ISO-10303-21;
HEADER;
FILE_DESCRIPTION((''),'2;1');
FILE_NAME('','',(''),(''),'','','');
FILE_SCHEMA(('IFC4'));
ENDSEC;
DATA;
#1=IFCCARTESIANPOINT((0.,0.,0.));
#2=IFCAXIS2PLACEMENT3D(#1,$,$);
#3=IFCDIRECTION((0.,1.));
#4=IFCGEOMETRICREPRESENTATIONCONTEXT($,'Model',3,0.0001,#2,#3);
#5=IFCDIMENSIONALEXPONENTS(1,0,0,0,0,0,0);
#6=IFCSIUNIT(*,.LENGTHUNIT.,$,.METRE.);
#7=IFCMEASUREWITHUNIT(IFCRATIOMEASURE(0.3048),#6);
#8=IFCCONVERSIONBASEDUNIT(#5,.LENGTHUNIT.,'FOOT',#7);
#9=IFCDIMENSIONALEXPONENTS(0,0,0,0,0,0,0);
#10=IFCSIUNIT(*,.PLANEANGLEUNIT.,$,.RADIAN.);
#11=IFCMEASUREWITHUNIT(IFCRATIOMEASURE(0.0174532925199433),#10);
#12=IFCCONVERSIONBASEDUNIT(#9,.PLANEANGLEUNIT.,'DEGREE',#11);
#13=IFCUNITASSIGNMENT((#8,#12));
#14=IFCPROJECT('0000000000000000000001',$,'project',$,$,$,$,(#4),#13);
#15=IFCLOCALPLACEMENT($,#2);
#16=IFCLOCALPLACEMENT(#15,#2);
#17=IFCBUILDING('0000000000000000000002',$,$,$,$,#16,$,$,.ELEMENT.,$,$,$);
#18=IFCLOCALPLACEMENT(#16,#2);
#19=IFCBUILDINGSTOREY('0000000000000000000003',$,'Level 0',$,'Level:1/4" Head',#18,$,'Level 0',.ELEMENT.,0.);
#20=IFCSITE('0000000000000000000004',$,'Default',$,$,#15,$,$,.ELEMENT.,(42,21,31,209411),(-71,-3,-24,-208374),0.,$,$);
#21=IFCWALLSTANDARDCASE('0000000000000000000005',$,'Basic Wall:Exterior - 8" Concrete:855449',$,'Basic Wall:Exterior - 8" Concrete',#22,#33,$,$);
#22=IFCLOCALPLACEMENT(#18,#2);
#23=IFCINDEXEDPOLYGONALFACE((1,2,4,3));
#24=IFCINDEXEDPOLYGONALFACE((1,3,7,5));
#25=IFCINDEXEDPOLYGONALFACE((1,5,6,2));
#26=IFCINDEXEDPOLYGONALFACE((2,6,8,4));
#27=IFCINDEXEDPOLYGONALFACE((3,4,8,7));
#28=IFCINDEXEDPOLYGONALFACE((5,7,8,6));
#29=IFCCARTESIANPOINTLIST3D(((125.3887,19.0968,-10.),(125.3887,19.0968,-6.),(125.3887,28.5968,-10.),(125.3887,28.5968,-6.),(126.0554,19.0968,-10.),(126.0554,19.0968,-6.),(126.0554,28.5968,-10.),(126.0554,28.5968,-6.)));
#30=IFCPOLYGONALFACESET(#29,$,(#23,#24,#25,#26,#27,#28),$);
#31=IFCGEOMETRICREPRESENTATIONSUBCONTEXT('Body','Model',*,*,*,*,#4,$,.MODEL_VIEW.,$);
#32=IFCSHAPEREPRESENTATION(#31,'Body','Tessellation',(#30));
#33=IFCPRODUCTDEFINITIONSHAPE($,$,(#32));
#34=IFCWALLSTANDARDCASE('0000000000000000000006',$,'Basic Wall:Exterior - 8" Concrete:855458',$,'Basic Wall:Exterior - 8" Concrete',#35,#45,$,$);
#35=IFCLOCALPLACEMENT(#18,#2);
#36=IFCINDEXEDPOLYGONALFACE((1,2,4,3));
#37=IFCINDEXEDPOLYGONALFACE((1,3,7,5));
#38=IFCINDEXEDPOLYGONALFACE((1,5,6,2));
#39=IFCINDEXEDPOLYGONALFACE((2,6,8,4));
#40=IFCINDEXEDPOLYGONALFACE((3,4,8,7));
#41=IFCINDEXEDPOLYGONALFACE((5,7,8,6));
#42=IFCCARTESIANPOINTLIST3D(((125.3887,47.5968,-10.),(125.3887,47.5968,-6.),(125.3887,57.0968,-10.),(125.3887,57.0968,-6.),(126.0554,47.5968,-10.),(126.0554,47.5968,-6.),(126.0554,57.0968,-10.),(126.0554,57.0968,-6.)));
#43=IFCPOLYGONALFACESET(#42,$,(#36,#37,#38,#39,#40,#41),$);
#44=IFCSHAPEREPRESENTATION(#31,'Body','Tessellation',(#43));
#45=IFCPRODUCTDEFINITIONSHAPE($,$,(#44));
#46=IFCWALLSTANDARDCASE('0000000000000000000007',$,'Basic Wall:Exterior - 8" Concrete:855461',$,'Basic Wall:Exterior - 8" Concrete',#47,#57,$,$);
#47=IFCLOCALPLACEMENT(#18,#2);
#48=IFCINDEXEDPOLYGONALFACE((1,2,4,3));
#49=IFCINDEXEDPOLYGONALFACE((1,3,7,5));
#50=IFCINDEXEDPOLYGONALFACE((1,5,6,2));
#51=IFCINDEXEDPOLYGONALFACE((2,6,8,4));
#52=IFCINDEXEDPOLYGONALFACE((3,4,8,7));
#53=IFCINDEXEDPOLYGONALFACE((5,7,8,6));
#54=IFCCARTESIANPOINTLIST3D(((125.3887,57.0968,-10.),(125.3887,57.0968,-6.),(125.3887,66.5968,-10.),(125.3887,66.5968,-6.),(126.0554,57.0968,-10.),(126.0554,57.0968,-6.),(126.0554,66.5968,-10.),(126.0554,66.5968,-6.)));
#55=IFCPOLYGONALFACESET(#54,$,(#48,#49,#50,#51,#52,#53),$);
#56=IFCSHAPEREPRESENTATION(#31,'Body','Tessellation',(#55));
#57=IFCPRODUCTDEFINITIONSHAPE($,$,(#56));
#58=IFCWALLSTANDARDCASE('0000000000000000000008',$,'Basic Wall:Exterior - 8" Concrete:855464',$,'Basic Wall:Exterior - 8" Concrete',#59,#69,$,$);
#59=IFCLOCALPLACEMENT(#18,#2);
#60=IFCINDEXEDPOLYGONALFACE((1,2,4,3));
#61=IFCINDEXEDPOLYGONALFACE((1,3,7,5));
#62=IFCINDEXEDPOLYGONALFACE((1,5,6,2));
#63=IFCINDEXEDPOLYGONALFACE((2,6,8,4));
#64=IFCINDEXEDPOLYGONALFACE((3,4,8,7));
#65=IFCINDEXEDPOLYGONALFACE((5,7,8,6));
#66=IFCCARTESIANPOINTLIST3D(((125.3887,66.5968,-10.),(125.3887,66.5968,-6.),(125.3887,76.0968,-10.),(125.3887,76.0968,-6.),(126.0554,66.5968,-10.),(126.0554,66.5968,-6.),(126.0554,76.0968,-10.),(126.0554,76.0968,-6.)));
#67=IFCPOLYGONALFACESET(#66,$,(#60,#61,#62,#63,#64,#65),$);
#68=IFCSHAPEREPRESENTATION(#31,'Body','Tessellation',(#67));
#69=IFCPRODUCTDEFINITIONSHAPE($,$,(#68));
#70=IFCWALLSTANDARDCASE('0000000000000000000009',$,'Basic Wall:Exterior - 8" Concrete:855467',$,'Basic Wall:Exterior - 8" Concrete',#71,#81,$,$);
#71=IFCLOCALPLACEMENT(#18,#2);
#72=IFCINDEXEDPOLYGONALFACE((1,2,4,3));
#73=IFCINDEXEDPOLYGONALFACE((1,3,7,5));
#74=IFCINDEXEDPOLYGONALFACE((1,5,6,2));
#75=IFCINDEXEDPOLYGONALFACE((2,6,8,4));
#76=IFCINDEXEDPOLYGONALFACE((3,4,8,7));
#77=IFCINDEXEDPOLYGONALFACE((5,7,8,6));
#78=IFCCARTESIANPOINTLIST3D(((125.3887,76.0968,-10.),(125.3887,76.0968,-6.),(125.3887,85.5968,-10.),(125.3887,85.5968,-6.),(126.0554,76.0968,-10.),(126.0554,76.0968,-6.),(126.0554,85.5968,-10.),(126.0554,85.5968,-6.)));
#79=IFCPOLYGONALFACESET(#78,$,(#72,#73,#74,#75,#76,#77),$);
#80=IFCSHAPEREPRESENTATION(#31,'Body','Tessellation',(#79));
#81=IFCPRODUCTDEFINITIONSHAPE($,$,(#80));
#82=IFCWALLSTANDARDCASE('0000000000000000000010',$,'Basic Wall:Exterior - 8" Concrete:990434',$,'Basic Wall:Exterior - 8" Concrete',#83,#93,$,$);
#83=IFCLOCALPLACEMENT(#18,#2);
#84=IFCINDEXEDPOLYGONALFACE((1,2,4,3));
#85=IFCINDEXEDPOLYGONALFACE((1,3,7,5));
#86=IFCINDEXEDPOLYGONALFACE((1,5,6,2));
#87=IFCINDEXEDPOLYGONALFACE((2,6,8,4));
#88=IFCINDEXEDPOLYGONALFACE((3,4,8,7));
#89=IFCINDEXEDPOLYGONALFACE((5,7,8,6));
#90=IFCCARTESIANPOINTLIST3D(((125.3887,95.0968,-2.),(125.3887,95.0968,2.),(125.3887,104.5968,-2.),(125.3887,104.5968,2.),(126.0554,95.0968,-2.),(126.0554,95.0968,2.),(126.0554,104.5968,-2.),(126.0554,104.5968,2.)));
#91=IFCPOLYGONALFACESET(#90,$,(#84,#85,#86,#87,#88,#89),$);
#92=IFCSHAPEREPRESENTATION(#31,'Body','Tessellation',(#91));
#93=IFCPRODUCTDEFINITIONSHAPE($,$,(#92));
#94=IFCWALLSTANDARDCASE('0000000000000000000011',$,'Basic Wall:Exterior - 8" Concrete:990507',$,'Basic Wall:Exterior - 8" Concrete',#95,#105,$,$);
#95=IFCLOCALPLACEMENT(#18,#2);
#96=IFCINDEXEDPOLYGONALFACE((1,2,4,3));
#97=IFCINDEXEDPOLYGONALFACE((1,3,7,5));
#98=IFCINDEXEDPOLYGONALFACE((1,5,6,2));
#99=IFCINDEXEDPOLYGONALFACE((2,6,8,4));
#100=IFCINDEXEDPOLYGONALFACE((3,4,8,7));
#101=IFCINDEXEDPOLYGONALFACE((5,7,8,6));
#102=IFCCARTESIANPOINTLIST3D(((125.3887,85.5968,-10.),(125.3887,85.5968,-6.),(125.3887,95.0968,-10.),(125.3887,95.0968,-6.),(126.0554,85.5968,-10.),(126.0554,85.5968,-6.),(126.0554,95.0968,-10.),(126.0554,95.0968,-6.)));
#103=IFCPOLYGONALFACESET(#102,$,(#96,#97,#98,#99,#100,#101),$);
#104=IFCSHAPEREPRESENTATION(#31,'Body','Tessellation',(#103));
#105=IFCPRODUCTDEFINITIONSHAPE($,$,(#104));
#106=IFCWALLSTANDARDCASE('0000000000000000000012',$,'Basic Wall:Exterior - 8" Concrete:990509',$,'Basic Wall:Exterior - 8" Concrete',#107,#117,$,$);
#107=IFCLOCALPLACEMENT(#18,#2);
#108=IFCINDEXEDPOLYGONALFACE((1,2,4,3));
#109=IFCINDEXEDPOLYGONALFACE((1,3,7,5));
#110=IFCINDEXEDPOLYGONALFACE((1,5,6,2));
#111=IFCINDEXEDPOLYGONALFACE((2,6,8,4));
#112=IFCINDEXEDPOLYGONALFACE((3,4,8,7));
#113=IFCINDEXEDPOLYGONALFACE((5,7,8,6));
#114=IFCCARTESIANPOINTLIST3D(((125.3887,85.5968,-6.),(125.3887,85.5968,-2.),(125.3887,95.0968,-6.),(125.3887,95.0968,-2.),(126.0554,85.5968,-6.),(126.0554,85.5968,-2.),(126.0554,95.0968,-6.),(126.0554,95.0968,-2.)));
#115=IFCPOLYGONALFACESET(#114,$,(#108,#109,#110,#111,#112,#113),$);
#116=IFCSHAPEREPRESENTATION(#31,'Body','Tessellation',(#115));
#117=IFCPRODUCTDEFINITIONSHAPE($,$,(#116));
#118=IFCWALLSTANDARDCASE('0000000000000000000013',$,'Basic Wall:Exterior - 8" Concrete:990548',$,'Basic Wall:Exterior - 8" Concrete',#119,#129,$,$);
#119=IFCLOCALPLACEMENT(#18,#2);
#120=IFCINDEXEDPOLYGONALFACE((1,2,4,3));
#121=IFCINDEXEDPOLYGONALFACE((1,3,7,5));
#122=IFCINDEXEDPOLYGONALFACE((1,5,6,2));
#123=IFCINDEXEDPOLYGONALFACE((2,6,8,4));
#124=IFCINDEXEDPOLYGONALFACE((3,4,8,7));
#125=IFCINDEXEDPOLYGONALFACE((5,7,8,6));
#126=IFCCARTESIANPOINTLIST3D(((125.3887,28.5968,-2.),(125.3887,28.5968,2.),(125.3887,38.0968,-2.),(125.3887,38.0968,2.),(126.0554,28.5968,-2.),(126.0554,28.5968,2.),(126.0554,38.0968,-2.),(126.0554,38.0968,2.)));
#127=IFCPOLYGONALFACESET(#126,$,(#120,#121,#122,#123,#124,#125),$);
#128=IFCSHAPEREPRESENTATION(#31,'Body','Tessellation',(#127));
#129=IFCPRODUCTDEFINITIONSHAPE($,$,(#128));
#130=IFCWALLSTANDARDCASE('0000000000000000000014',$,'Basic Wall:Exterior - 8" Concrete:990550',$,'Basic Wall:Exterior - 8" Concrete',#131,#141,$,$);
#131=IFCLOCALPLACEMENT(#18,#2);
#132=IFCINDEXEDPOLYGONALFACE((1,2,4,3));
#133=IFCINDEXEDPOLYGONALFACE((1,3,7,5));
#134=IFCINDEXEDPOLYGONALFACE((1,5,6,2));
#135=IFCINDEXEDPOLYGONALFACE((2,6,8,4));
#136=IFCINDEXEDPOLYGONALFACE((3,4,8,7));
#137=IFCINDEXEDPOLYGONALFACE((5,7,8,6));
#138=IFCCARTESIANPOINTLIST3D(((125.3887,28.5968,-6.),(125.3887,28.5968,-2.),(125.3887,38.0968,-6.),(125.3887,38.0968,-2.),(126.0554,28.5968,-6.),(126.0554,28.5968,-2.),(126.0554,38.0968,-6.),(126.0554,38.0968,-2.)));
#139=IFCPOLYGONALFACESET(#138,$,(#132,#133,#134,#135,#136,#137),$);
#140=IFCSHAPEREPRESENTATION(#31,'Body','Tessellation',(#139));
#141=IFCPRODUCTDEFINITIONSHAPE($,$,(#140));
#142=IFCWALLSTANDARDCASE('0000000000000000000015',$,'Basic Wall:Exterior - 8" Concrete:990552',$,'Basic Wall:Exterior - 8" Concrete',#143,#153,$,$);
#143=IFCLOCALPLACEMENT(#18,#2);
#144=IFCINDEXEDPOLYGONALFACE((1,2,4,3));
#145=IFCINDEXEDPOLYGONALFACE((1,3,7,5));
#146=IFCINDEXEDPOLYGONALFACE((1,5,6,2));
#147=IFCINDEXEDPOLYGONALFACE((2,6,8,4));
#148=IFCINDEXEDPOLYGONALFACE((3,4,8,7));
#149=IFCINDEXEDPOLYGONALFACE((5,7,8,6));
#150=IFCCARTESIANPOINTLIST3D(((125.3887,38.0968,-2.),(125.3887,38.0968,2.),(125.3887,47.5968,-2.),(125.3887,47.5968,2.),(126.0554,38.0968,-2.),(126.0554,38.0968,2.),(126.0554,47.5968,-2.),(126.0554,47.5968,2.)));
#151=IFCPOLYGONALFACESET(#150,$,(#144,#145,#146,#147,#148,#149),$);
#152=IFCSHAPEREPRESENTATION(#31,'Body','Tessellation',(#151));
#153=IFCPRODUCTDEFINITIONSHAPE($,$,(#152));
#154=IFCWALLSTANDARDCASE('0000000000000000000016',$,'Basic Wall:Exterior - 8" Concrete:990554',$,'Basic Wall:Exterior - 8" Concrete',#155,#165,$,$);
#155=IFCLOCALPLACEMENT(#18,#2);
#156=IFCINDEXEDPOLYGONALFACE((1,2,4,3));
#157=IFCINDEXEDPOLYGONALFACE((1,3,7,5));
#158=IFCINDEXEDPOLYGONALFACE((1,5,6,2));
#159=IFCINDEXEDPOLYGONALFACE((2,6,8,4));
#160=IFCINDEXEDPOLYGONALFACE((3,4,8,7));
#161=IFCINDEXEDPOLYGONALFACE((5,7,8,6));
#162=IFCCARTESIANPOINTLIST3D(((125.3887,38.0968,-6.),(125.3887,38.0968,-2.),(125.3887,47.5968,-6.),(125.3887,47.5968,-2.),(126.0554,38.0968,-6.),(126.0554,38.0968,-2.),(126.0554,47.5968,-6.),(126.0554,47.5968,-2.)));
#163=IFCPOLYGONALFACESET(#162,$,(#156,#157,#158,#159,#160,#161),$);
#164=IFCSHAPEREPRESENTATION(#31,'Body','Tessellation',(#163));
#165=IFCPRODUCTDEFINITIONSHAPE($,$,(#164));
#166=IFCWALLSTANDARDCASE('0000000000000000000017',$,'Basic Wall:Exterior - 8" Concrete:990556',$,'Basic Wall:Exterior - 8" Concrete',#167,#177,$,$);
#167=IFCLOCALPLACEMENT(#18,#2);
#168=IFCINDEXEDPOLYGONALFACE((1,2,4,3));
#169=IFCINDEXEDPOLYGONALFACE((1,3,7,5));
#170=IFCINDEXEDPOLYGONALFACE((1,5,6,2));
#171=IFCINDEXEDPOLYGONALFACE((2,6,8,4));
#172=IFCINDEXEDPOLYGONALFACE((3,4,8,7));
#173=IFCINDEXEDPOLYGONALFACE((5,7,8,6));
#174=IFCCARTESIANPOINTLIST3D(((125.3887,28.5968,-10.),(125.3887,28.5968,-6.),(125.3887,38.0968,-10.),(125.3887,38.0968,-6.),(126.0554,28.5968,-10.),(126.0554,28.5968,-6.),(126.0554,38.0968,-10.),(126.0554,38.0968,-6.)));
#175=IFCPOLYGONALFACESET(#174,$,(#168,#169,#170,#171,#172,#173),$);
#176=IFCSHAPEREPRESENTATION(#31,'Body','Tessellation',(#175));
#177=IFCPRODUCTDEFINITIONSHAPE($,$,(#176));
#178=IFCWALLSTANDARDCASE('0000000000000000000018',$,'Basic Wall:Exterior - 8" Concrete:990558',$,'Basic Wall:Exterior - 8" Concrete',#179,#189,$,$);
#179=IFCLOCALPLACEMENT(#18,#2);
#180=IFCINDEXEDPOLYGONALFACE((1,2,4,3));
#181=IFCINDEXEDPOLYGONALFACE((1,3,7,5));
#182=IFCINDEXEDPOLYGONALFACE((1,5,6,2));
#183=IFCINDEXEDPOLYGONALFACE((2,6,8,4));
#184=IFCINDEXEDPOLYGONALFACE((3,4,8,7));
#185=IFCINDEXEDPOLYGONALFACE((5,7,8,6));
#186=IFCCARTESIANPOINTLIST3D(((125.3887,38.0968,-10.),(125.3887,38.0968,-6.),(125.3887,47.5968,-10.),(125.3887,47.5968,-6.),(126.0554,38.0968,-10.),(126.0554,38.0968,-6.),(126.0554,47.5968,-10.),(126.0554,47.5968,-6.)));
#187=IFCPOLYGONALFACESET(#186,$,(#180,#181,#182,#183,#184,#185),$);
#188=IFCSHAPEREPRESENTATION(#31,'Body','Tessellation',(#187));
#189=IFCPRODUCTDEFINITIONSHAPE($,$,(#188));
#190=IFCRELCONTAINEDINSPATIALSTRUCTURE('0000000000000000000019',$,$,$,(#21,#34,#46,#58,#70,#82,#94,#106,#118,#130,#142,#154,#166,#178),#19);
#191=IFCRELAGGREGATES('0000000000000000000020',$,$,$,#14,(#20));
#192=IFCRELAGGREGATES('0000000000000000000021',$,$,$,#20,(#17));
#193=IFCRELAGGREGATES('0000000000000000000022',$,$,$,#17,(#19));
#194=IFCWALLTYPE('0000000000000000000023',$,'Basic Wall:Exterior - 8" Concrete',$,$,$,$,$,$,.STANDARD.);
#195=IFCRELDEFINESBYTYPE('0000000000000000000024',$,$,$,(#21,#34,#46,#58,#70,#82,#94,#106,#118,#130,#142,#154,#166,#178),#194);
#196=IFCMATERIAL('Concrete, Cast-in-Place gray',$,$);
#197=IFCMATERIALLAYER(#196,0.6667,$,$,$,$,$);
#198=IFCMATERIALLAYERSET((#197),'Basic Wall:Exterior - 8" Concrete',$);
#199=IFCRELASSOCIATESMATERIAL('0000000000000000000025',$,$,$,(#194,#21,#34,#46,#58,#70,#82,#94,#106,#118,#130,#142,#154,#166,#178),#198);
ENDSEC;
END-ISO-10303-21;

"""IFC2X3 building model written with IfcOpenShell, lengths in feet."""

from ifc_helpers import new_model, entity, si_unit, converted_unit, direction, frame, frame_2d, origin, place, context, subcontext, project, spatial, rectangle, extrude, material, layer, layer_set, layer_usage, type_object, element, save


model = new_model("IFC2X3")

# Units and contexts
model_context = context("Model", 3, precision=0.0001, world=origin(), true_north=direction((0.0, 1.0)))
body_context = subcontext(model_context, "Body", "Model", "MODEL_VIEW")
ifc_project = project(units=[converted_unit("LENGTHUNIT", "FOOT", entity("IfcRatioMeasure", 0.3048), si_unit("LENGTHUNIT", "METRE"), dimensions=[1, 0, 0, 0, 0, 0, 0]), converted_unit("PLANEANGLEUNIT", "DEGREE", entity("IfcRatioMeasure", 0.0174532925199433), si_unit("PLANEANGLEUNIT", "RADIAN"), dimensions=[0, 0, 0, 0, 0, 0, 0])], contexts=[model_context])

# Site, building, storey
site_placement = place(None, origin())
site = spatial("IfcSite", under=ifc_project, at=site_placement, Name="Default", CompositionType="ELEMENT", RefLatitude=(42, 21, 31, 209411), RefLongitude=(-71, -3, -24, -208374), RefElevation=0.0)
building_placement = place(site_placement, origin())
building = spatial("IfcBuilding", under=site, at=building_placement, CompositionType="ELEMENT")
storey_placement = place(building_placement, origin())
storey = spatial("IfcBuildingStorey", under=building, at=storey_placement, Name="Level 0", ObjectType="Level:1/4\" Head", LongName="Level 0", CompositionType="ELEMENT", Elevation=0.0)

# Walls
ifc_material_1 = material(Name="Concrete, Cast-in-Place gray")
ifc_layer = layer(ifc_material_1, 0.6667)
ifc_layer_set = layer_set([ifc_layer], Name="Basic Wall:Exterior - 8\" Concrete")
wall_type = type_object("IfcWallType", Name="Basic Wall:Exterior - 8\" Concrete", PredefinedType="STANDARD", material=ifc_layer_set)
ifc_layer_usage_1 = layer_usage(ifc_layer_set, "AXIS2", "NEGATIVE", 0.3333)
wall_1_placement = place(storey_placement, frame((125.722, 19.0968, -10.0), z_axis=(0.0, 0.0, 1.0), x_axis=(0.0, 1.0, 0.0)))
element("IfcWallStandardCase", 1, at=wall_1_placement, inside=storey, type_object=wall_type, material=ifc_layer_usage_1, Name="Basic Wall:Exterior - 8\" Concrete:855449", ObjectType="Basic Wall:Exterior - 8\" Concrete", context=body_context, shape_type="SweptSolid", body=[
    extrude(rectangle(XDim=9.5, YDim=0.6667, at=frame_2d((4.75, 0.0), x_axis=(-1.0, 0.0))), origin(), (0.0, 0.0, 1.0), 4.0),
])
ifc_layer_usage_2 = layer_usage(ifc_layer_set, "AXIS2", "NEGATIVE", 0.3333)
wall_2_placement = place(storey_placement, frame((125.722, 47.5968, -10.0), z_axis=(0.0, 0.0, 1.0), x_axis=(0.0, 1.0, 0.0)))
element("IfcWallStandardCase", 2, at=wall_2_placement, inside=storey, type_object=wall_type, material=ifc_layer_usage_2, Name="Basic Wall:Exterior - 8\" Concrete:855458", ObjectType="Basic Wall:Exterior - 8\" Concrete", context=body_context, shape_type="SweptSolid", body=[
    extrude(rectangle(XDim=9.5, YDim=0.6667, at=frame_2d((4.75, 0.0), x_axis=(-1.0, 0.0))), origin(), (0.0, 0.0, 1.0), 4.0),
])
ifc_layer_usage_3 = layer_usage(ifc_layer_set, "AXIS2", "NEGATIVE", 0.3333)
wall_3_placement = place(storey_placement, frame((125.722, 57.0968, -10.0), z_axis=(0.0, 0.0, 1.0), x_axis=(0.0, 1.0, 0.0)))
element("IfcWallStandardCase", 3, at=wall_3_placement, inside=storey, type_object=wall_type, material=ifc_layer_usage_3, Name="Basic Wall:Exterior - 8\" Concrete:855461", ObjectType="Basic Wall:Exterior - 8\" Concrete", context=body_context, shape_type="SweptSolid", body=[
    extrude(rectangle(XDim=9.5, YDim=0.6667, at=frame_2d((4.75, 0.0), x_axis=(-1.0, 0.0))), origin(), (0.0, 0.0, 1.0), 4.0),
])
ifc_layer_usage_4 = layer_usage(ifc_layer_set, "AXIS2", "NEGATIVE", 0.3333)
wall_4_placement = place(storey_placement, frame((125.722, 66.5968, -10.0), z_axis=(0.0, 0.0, 1.0), x_axis=(0.0, 1.0, 0.0)))
element("IfcWallStandardCase", 4, at=wall_4_placement, inside=storey, type_object=wall_type, material=ifc_layer_usage_4, Name="Basic Wall:Exterior - 8\" Concrete:855464", ObjectType="Basic Wall:Exterior - 8\" Concrete", context=body_context, shape_type="SweptSolid", body=[
    extrude(rectangle(XDim=9.5, YDim=0.6667, at=frame_2d((4.75, 0.0), x_axis=(-1.0, 0.0))), origin(), (0.0, 0.0, 1.0), 4.0),
])
ifc_layer_usage_5 = layer_usage(ifc_layer_set, "AXIS2", "NEGATIVE", 0.3333)
wall_5_placement = place(storey_placement, frame((125.722, 76.0968, -10.0), z_axis=(0.0, 0.0, 1.0), x_axis=(0.0, 1.0, 0.0)))
element("IfcWallStandardCase", 5, at=wall_5_placement, inside=storey, type_object=wall_type, material=ifc_layer_usage_5, Name="Basic Wall:Exterior - 8\" Concrete:855467", ObjectType="Basic Wall:Exterior - 8\" Concrete", context=body_context, shape_type="SweptSolid", body=[
    extrude(rectangle(XDim=9.5, YDim=0.6667, at=frame_2d((4.75, 0.0), x_axis=(-1.0, 0.0))), origin(), (0.0, 0.0, 1.0), 4.0),
])
ifc_layer_usage_6 = layer_usage(ifc_layer_set, "AXIS2", "NEGATIVE", 0.3333)
wall_6_placement = place(storey_placement, frame((125.722, 95.0968, -2.0), z_axis=(0.0, 0.0, 1.0), x_axis=(0.0, 1.0, 0.0)))
element("IfcWallStandardCase", 6, at=wall_6_placement, inside=storey, type_object=wall_type, material=ifc_layer_usage_6, Name="Basic Wall:Exterior - 8\" Concrete:990434", ObjectType="Basic Wall:Exterior - 8\" Concrete", context=body_context, shape_type="SweptSolid", body=[
    extrude(rectangle(XDim=9.5, YDim=0.6667, at=frame_2d((4.75, 0.0), x_axis=(-1.0, 0.0))), origin(), (0.0, 0.0, 1.0), 4.0),
])
ifc_layer_usage_7 = layer_usage(ifc_layer_set, "AXIS2", "NEGATIVE", 0.3333)
wall_7_placement = place(storey_placement, frame((125.722, 85.5968, -10.0), z_axis=(0.0, 0.0, 1.0), x_axis=(0.0, 1.0, 0.0)))
element("IfcWallStandardCase", 7, at=wall_7_placement, inside=storey, type_object=wall_type, material=ifc_layer_usage_7, Name="Basic Wall:Exterior - 8\" Concrete:990507", ObjectType="Basic Wall:Exterior - 8\" Concrete", context=body_context, shape_type="SweptSolid", body=[
    extrude(rectangle(XDim=9.5, YDim=0.6667, at=frame_2d((4.75, 0.0), x_axis=(-1.0, 0.0))), origin(), (0.0, 0.0, 1.0), 4.0),
])
ifc_layer_usage_8 = layer_usage(ifc_layer_set, "AXIS2", "NEGATIVE", 0.3333)
wall_8_placement = place(storey_placement, frame((125.722, 85.5968, -6.0), z_axis=(0.0, 0.0, 1.0), x_axis=(0.0, 1.0, 0.0)))
element("IfcWallStandardCase", 8, at=wall_8_placement, inside=storey, type_object=wall_type, material=ifc_layer_usage_8, Name="Basic Wall:Exterior - 8\" Concrete:990509", ObjectType="Basic Wall:Exterior - 8\" Concrete", context=body_context, shape_type="SweptSolid", body=[
    extrude(rectangle(XDim=9.5, YDim=0.6667, at=frame_2d((4.75, 0.0), x_axis=(-1.0, 0.0))), origin(), (0.0, 0.0, 1.0), 4.0),
])
ifc_layer_usage_9 = layer_usage(ifc_layer_set, "AXIS2", "NEGATIVE", 0.3333)
wall_9_placement = place(storey_placement, frame((125.722, 28.5968, -2.0), z_axis=(0.0, 0.0, 1.0), x_axis=(0.0, 1.0, 0.0)))
element("IfcWallStandardCase", 9, at=wall_9_placement, inside=storey, type_object=wall_type, material=ifc_layer_usage_9, Name="Basic Wall:Exterior - 8\" Concrete:990548", ObjectType="Basic Wall:Exterior - 8\" Concrete", context=body_context, shape_type="SweptSolid", body=[
    extrude(rectangle(XDim=9.5, YDim=0.6667, at=frame_2d((4.75, 0.0), x_axis=(-1.0, 0.0))), origin(), (0.0, 0.0, 1.0), 4.0),
])
ifc_layer_usage_10 = layer_usage(ifc_layer_set, "AXIS2", "NEGATIVE", 0.3333)
wall_10_placement = place(storey_placement, frame((125.722, 28.5968, -6.0), z_axis=(0.0, 0.0, 1.0), x_axis=(0.0, 1.0, 0.0)))
element("IfcWallStandardCase", 10, at=wall_10_placement, inside=storey, type_object=wall_type, material=ifc_layer_usage_10, Name="Basic Wall:Exterior - 8\" Concrete:990550", ObjectType="Basic Wall:Exterior - 8\" Concrete", context=body_context, shape_type="SweptSolid", body=[
    extrude(rectangle(XDim=9.5, YDim=0.6667, at=frame_2d((4.75, 0.0), x_axis=(-1.0, 0.0))), origin(), (0.0, 0.0, 1.0), 4.0),
])
ifc_layer_usage_11 = layer_usage(ifc_layer_set, "AXIS2", "NEGATIVE", 0.3333)
wall_11_placement = place(storey_placement, frame((125.722, 38.0968, -2.0), z_axis=(0.0, 0.0, 1.0), x_axis=(0.0, 1.0, 0.0)))
element("IfcWallStandardCase", 11, at=wall_11_placement, inside=storey, type_object=wall_type, material=ifc_layer_usage_11, Name="Basic Wall:Exterior - 8\" Concrete:990552", ObjectType="Basic Wall:Exterior - 8\" Concrete", context=body_context, shape_type="SweptSolid", body=[
    extrude(rectangle(XDim=9.5, YDim=0.6667, at=frame_2d((4.75, 0.0), x_axis=(-1.0, 0.0))), origin(), (0.0, 0.0, 1.0), 4.0),
])
ifc_layer_usage_12 = layer_usage(ifc_layer_set, "AXIS2", "NEGATIVE", 0.3333)
wall_12_placement = place(storey_placement, frame((125.722, 38.0968, -6.0), z_axis=(0.0, 0.0, 1.0), x_axis=(0.0, 1.0, 0.0)))
element("IfcWallStandardCase", 12, at=wall_12_placement, inside=storey, type_object=wall_type, material=ifc_layer_usage_12, Name="Basic Wall:Exterior - 8\" Concrete:990554", ObjectType="Basic Wall:Exterior - 8\" Concrete", context=body_context, shape_type="SweptSolid", body=[
    extrude(rectangle(XDim=9.5, YDim=0.6667, at=frame_2d((4.75, 0.0), x_axis=(-1.0, 0.0))), origin(), (0.0, 0.0, 1.0), 4.0),
])
ifc_layer_usage_13 = layer_usage(ifc_layer_set, "AXIS2", "NEGATIVE", 0.3333)
wall_13_placement = place(storey_placement, frame((125.722, 28.5968, -10.0), z_axis=(0.0, 0.0, 1.0), x_axis=(0.0, 1.0, 0.0)))
element("IfcWallStandardCase", 13, at=wall_13_placement, inside=storey, type_object=wall_type, material=ifc_layer_usage_13, Name="Basic Wall:Exterior - 8\" Concrete:990556", ObjectType="Basic Wall:Exterior - 8\" Concrete", context=body_context, shape_type="SweptSolid", body=[
    extrude(rectangle(XDim=9.5, YDim=0.6667, at=frame_2d((4.75, 0.0), x_axis=(-1.0, 0.0))), origin(), (0.0, 0.0, 1.0), 4.0),
])
ifc_layer_usage_14 = layer_usage(ifc_layer_set, "AXIS2", "NEGATIVE", 0.3333)
wall_14_placement = place(storey_placement, frame((125.722, 38.0968, -10.0), z_axis=(0.0, 0.0, 1.0), x_axis=(0.0, 1.0, 0.0)))
element("IfcWallStandardCase", 14, at=wall_14_placement, inside=storey, type_object=wall_type, material=ifc_layer_usage_14, Name="Basic Wall:Exterior - 8\" Concrete:990558", ObjectType="Basic Wall:Exterior - 8\" Concrete", context=body_context, shape_type="SweptSolid", body=[
    extrude(rectangle(XDim=9.5, YDim=0.6667, at=frame_2d((4.75, 0.0), x_axis=(-1.0, 0.0))), origin(), (0.0, 0.0, 1.0), 4.0),
])

save(model, "model.ifc")
